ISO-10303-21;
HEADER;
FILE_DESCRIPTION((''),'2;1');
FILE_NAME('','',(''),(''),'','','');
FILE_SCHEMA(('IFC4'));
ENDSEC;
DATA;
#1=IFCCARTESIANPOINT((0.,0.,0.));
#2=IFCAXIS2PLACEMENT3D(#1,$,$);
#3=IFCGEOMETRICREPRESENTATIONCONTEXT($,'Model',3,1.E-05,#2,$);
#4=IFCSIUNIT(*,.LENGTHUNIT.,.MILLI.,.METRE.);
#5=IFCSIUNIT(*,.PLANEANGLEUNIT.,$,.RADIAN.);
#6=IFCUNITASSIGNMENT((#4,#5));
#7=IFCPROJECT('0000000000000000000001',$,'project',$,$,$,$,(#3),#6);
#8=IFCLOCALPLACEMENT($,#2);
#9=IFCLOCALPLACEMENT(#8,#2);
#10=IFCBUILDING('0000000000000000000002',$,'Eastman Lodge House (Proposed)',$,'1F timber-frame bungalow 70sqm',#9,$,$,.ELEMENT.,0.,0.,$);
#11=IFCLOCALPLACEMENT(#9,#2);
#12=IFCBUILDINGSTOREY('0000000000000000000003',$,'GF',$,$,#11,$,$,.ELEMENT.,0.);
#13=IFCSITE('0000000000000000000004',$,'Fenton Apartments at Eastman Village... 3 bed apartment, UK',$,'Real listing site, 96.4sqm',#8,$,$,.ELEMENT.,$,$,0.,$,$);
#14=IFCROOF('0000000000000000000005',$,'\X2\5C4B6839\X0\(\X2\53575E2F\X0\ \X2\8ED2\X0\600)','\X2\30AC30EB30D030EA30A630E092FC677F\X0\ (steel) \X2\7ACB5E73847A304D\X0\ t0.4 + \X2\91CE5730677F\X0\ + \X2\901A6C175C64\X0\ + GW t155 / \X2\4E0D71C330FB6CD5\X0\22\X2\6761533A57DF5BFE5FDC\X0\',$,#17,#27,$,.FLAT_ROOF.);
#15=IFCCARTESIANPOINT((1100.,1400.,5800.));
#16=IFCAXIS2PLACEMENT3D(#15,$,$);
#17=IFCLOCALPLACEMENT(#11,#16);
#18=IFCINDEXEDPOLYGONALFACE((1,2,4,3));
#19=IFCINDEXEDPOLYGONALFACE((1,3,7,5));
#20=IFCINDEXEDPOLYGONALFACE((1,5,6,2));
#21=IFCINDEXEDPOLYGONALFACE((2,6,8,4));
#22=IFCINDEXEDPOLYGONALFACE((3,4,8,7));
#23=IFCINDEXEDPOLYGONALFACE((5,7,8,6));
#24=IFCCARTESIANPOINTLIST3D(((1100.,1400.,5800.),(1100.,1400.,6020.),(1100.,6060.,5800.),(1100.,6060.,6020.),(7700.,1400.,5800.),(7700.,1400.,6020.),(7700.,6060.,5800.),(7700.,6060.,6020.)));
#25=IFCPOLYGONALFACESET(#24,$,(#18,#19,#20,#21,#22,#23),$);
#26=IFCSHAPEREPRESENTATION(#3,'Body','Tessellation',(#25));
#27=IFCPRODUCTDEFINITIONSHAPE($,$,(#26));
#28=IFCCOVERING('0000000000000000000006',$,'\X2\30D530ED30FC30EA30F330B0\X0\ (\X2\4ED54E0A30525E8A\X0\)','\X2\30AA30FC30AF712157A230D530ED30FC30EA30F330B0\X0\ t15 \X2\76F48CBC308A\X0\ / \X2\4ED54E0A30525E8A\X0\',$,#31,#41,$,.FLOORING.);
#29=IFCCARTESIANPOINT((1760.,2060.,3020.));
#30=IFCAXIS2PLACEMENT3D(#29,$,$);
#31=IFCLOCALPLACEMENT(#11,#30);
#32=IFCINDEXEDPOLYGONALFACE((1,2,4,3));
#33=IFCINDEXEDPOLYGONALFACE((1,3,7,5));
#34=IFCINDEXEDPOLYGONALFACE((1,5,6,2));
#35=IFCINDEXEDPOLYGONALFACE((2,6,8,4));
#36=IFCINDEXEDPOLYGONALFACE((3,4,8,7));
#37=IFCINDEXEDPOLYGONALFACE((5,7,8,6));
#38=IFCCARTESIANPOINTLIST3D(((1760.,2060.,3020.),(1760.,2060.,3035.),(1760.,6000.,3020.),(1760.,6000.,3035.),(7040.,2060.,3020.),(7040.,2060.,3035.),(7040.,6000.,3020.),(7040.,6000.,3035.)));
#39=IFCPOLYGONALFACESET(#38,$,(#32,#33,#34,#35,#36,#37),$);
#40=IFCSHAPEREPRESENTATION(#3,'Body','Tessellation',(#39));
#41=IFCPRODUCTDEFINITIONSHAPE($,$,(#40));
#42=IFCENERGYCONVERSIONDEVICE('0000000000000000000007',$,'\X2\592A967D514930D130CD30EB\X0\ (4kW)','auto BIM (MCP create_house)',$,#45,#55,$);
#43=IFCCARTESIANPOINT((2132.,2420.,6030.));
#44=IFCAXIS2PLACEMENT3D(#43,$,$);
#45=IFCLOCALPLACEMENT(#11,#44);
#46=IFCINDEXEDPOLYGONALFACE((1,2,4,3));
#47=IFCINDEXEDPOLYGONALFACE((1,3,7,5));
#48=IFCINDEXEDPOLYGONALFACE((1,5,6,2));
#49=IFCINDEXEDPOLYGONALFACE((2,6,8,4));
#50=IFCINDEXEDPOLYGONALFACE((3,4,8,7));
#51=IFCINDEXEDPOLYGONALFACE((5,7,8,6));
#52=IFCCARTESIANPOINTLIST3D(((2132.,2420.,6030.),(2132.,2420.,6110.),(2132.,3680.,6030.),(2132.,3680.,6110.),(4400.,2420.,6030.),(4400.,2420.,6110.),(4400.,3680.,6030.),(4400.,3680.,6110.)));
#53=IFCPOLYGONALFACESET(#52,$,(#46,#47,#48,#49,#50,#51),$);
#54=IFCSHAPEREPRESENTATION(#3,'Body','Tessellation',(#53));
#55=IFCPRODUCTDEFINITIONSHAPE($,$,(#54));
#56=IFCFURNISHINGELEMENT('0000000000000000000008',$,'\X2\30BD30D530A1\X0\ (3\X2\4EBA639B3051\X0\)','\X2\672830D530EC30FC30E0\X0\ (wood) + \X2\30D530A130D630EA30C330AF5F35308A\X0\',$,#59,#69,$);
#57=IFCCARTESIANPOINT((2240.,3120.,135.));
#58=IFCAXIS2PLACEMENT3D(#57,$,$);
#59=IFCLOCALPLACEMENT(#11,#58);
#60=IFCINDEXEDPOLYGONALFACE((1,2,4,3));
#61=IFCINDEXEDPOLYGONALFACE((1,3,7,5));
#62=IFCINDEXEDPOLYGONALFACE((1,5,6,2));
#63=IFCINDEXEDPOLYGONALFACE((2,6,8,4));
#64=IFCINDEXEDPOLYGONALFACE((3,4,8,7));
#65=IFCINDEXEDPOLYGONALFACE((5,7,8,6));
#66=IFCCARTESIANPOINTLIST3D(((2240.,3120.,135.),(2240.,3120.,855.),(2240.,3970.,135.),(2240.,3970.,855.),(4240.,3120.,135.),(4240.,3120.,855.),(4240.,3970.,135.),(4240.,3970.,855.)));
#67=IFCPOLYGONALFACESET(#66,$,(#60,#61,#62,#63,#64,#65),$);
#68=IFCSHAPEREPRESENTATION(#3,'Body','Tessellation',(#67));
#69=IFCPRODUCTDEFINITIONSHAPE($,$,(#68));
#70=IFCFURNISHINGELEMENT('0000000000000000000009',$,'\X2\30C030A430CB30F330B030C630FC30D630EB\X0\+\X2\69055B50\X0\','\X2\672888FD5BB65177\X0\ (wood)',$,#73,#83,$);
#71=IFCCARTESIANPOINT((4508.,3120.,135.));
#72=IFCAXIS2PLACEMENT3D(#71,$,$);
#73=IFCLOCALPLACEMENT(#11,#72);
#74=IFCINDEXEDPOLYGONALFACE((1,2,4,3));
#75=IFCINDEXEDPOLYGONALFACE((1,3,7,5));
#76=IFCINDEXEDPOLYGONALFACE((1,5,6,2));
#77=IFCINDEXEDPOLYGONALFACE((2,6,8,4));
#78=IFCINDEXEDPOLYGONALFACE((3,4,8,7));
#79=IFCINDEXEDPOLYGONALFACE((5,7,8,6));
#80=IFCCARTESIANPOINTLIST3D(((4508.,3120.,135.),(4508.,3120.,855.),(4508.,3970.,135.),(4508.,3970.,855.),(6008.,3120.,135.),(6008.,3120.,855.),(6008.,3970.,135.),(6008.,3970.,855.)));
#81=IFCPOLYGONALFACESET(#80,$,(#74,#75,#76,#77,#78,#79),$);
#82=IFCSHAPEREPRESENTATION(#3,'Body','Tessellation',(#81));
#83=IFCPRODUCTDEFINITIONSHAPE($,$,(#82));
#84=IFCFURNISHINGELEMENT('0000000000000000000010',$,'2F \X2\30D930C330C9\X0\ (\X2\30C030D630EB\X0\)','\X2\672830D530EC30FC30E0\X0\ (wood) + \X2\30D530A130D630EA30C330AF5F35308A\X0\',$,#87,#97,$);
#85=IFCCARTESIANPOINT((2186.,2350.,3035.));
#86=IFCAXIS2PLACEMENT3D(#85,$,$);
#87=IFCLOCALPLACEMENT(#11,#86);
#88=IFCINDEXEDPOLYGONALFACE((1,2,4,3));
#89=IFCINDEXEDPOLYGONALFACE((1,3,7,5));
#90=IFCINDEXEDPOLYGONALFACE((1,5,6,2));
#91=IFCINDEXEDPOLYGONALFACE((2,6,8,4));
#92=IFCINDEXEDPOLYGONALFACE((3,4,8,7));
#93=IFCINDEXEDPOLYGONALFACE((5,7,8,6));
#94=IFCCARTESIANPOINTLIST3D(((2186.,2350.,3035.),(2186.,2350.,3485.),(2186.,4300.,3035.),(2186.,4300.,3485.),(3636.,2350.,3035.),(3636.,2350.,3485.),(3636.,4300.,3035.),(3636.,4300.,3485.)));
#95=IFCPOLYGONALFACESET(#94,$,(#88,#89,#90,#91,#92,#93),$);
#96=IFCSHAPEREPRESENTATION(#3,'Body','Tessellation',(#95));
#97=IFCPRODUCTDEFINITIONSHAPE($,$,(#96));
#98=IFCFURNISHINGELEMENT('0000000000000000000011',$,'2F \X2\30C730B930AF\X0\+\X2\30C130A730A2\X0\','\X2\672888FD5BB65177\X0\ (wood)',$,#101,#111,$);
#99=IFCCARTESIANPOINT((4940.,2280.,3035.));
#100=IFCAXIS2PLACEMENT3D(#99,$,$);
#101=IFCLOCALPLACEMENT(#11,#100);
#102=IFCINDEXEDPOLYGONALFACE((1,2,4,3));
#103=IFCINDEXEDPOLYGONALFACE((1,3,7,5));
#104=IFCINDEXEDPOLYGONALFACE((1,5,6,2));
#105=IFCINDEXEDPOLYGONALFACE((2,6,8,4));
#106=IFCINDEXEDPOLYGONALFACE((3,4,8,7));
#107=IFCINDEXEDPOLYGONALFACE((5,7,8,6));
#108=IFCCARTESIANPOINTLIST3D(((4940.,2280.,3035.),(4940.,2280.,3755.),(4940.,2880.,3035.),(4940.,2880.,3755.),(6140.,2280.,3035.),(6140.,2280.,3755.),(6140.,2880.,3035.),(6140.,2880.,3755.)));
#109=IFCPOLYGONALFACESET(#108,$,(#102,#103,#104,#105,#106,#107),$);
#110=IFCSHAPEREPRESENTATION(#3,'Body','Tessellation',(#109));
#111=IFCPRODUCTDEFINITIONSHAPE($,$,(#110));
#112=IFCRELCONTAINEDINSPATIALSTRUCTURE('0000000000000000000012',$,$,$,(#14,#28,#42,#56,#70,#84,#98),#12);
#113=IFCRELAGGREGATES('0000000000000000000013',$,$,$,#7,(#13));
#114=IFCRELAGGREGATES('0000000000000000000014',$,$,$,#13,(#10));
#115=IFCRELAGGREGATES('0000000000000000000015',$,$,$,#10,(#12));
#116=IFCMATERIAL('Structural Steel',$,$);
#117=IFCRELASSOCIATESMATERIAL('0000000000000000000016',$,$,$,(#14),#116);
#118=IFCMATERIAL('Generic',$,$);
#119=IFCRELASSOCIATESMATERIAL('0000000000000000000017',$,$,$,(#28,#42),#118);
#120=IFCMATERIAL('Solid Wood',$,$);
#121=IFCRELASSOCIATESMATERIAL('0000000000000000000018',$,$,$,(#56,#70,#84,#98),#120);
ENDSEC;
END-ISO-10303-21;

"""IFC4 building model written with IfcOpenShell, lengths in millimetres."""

from ifc_helpers import new_model, si_unit, frame, frame_2d, origin, place, context, project, spatial, rectangle, extrude, material, element, save


model = new_model("IFC4")

# Units and contexts
model_context = context("Model", 3, precision=1e-05, world=origin())
ifc_project = project(units=[si_unit("LENGTHUNIT", "METRE", prefix="MILLI"), si_unit("PLANEANGLEUNIT", "RADIAN")], contexts=[model_context])

# Site, building, storey
site_placement = place(None, origin())
site = spatial("IfcSite", under=ifc_project, at=site_placement, Name="Fenton Apartments at Eastman Village... 3 bed apartment, UK", ObjectType="Real listing site, 96.4sqm", CompositionType="ELEMENT", RefElevation=0.0)
building_placement = place(site_placement, origin())
building = spatial("IfcBuilding", under=site, at=building_placement, Name="Eastman Lodge House (Proposed)", ObjectType="1F timber-frame bungalow 70sqm", CompositionType="ELEMENT", ElevationOfRefHeight=0.0, ElevationOfTerrain=0.0)
storey_placement = place(building_placement, origin())
storey = spatial("IfcBuildingStorey", under=building, at=storey_placement, Name="GF", CompositionType="ELEMENT", Elevation=0.0)

# Shared definitions
ifc_material_1 = material(Name="Solid Wood")

# Shared definitions
ifc_material_2 = material(Name="Generic")

# Roof
ifc_material_3 = material(Name="Structural Steel")
for number, where, name in (
    (1, (1100.0, 1400.0, 5800.0), "屋根(南帯 軒600)"),
):
    element("IfcRoof", number, at=place(storey_placement, frame(where)), inside=storey, material=ifc_material_3, Name=name, Description="ガルバリウム鋼板 (steel) 立平葺き t0.4 + 野地板 + 通気層 + GW t155 / 不燃・法22条区域対応", PredefinedType="FLAT_ROOF", context=model_context, shape_type="SweptSolid", body=[
        extrude(rectangle(XDim=6600.0, YDim=4660.0, at=frame_2d((3300.0, 2330.0))), frame((1100.0, 1400.0, 5800.0)), (0.0, 0.0, 1.0), 220.0),
    ])

# Covering
covering_placement = place(storey_placement, frame((1760.0, 2060.0, 3020.0)))
element("IfcCovering", 2, at=covering_placement, inside=storey, material=ifc_material_2, Name="フローリング (仕上げ床)", Description="オーク無垢フローリング t15 直貼り / 仕上げ床", PredefinedType="FLOORING", context=model_context, shape_type="SweptSolid", body=[
    extrude(rectangle(XDim=5280.0, YDim=3940.0, at=frame_2d((2640.0, 1970.0))), frame((1760.0, 2060.0, 3020.0)), (0.0, 0.0, 1.0), 15.0),
])

# Energy conversion device
energy_conversion_device_placement = place(storey_placement, frame((2132.0, 2420.0, 6030.0)))
element("IfcEnergyConversionDevice", 3, at=energy_conversion_device_placement, inside=storey, material=ifc_material_2, Name="太陽光パネル (4kW)", Description="auto BIM (MCP create_house)", context=model_context, shape_type="SweptSolid", body=[
    extrude(rectangle(XDim=2268.0, YDim=1260.0, at=frame_2d((1134.0, 630.0))), frame((2132.0, 2420.0, 6030.0)), (0.0, 0.0, 1.0), 80.0),
])

# Furnishing elements
furnishing_1_placement = place(storey_placement, frame((2240.0, 3120.0, 135.0)))
element("IfcFurnishingElement", 4, at=furnishing_1_placement, inside=storey, material=ifc_material_1, Name="ソファ (3人掛け)", Description="木フレーム (wood) + ファブリック張り", context=model_context, shape_type="SweptSolid", body=[
    extrude(rectangle(XDim=2000.0, YDim=850.0, at=frame_2d((1000.0, 425.0))), frame((2240.0, 3120.0, 135.0)), (0.0, 0.0, 1.0), 720.0),
])
furnishing_2_placement = place(storey_placement, frame((4508.0, 3120.0, 135.0)))
element("IfcFurnishingElement", 5, at=furnishing_2_placement, inside=storey, material=ifc_material_1, Name="ダイニングテーブル+椅子", Description="木製家具 (wood)", context=model_context, shape_type="SweptSolid", body=[
    extrude(rectangle(XDim=1500.0, YDim=850.0, at=frame_2d((750.0, 425.0))), frame((4508.0, 3120.0, 135.0)), (0.0, 0.0, 1.0), 720.0),
])
furnishing_3_placement = place(storey_placement, frame((2186.0, 2350.0, 3035.0)))
element("IfcFurnishingElement", 6, at=furnishing_3_placement, inside=storey, material=ifc_material_1, Name="2F ベッド (ダブル)", Description="木フレーム (wood) + ファブリック張り", context=model_context, shape_type="SweptSolid", body=[
    extrude(rectangle(XDim=1450.0, YDim=1950.0, at=frame_2d((725.0, 975.0))), frame((2186.0, 2350.0, 3035.0)), (0.0, 0.0, 1.0), 450.0),
])
furnishing_4_placement = place(storey_placement, frame((4940.0, 2280.0, 3035.0)))
element("IfcFurnishingElement", 7, at=furnishing_4_placement, inside=storey, material=ifc_material_1, Name="2F デスク+チェア", Description="木製家具 (wood)", context=model_context, shape_type="SweptSolid", body=[
    extrude(rectangle(XDim=1200.0, YDim=600.0, at=frame_2d((600.0, 300.0))), frame((4940.0, 2280.0, 3035.0)), (0.0, 0.0, 1.0), 720.0),
])

save(model, "model.ifc")
